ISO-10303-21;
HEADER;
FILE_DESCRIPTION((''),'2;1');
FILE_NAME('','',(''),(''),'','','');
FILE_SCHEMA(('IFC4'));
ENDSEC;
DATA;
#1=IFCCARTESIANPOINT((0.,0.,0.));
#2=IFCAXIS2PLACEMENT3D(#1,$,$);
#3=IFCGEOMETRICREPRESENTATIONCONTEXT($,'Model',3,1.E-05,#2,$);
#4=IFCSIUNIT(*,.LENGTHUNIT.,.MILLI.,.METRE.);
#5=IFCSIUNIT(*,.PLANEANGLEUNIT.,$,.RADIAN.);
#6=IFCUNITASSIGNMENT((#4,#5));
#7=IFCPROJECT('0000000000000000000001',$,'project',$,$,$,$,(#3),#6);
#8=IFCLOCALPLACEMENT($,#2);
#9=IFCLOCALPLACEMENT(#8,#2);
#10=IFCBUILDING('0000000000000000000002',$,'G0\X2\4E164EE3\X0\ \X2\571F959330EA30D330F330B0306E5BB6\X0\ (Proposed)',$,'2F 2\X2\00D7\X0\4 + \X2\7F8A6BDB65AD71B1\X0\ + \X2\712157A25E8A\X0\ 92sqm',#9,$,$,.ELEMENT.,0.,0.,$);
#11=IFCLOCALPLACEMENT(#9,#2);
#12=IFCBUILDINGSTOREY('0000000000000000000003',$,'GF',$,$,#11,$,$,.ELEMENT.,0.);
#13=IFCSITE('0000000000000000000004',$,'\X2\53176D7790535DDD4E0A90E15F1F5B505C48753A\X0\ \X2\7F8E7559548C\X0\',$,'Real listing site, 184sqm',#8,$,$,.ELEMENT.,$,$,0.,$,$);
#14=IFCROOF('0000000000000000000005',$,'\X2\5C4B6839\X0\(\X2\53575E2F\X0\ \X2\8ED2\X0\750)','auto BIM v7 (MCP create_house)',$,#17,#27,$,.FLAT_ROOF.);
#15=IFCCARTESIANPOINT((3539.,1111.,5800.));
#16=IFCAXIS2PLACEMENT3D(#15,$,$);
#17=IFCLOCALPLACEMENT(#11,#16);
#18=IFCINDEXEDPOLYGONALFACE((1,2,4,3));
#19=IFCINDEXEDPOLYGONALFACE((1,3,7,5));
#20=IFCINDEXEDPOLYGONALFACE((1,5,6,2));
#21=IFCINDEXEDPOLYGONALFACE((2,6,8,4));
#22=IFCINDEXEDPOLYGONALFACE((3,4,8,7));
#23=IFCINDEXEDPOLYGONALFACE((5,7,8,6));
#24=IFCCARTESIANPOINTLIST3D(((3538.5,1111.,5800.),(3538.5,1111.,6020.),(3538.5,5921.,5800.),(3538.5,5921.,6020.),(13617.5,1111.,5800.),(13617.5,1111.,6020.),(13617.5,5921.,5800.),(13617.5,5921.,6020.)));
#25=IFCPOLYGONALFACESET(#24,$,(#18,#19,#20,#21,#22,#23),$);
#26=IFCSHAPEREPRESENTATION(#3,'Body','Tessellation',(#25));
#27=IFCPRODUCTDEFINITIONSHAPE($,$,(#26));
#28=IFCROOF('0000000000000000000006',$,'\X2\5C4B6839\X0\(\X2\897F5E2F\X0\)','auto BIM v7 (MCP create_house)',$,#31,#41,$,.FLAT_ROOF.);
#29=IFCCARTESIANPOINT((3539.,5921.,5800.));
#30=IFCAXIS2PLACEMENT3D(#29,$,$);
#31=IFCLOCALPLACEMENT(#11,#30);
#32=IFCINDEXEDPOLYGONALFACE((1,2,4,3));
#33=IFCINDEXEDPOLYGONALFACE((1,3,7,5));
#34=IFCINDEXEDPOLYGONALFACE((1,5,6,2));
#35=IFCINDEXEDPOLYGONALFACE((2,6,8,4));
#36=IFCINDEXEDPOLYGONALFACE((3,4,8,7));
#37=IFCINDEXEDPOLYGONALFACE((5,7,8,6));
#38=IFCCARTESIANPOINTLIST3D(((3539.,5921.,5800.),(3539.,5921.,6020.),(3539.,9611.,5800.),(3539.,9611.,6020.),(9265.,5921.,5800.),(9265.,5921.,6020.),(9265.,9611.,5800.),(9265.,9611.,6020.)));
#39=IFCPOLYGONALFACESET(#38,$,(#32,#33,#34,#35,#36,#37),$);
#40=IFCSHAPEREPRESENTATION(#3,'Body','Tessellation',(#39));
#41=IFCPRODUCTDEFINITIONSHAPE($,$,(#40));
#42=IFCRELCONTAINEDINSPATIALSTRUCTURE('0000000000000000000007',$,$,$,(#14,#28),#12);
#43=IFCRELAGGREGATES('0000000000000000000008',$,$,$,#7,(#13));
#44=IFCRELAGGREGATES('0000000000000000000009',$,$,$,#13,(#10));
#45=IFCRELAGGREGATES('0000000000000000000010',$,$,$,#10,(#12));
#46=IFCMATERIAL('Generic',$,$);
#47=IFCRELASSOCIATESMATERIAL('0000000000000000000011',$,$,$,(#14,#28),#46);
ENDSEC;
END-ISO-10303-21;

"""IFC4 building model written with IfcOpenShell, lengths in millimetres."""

from ifc_helpers import new_model, si_unit, frame, frame_2d, origin, place, context, project, spatial, rectangle, extrude, material, element, save


model = new_model("IFC4")

# Units and contexts
model_context = context("Model", 3, precision=1e-05, world=origin())
ifc_project = project(units=[si_unit("LENGTHUNIT", "METRE", prefix="MILLI"), si_unit("PLANEANGLEUNIT", "RADIAN")], contexts=[model_context])

# Site, building, storey
site_placement = place(None, origin())
site = spatial("IfcSite", under=ifc_project, at=site_placement, Name="北海道川上郡弟子屈町 美留和", ObjectType="Real listing site, 184sqm", CompositionType="ELEMENT", RefElevation=0.0)
building_placement = place(site_placement, origin())
building = spatial("IfcBuilding", under=site, at=building_placement, Name="G0世代 土間リビングの家 (Proposed)", ObjectType="2F 2×4 + 羊毛断熱 + 無垢床 92sqm", CompositionType="ELEMENT", ElevationOfRefHeight=0.0, ElevationOfTerrain=0.0)
storey_placement = place(building_placement, origin())
storey = spatial("IfcBuildingStorey", under=building, at=storey_placement, Name="GF", CompositionType="ELEMENT", Elevation=0.0)

# Shared definitions
ifc_material = material(Name="Generic")

# Roofs
roof_1_placement = place(storey_placement, frame((3539.0, 1111.0, 5800.0)))
element("IfcRoof", 1, at=roof_1_placement, inside=storey, material=ifc_material, Name="屋根(南帯 軒750)", Description="auto BIM v7 (MCP create_house)", PredefinedType="FLAT_ROOF", context=model_context, shape_type="SweptSolid", body=[
    extrude(rectangle(XDim=10079.0, YDim=4810.0, at=frame_2d((5039.0, 2405.0))), frame((3539.0, 1111.0, 5800.0)), (0.0, 0.0, 1.0), 220.0),
])
roof_2_placement = place(storey_placement, frame((3539.0, 5921.0, 5800.0)))
element("IfcRoof", 2, at=roof_2_placement, inside=storey, material=ifc_material, Name="屋根(西帯)", Description="auto BIM v7 (MCP create_house)", PredefinedType="FLAT_ROOF", context=model_context, shape_type="SweptSolid", body=[
    extrude(rectangle(XDim=5726.0, YDim=3690.0, at=frame_2d((2863.0, 1845.0))), frame((3539.0, 5921.0, 5800.0)), (0.0, 0.0, 1.0), 220.0),
])

save(model, "model.ifc")
